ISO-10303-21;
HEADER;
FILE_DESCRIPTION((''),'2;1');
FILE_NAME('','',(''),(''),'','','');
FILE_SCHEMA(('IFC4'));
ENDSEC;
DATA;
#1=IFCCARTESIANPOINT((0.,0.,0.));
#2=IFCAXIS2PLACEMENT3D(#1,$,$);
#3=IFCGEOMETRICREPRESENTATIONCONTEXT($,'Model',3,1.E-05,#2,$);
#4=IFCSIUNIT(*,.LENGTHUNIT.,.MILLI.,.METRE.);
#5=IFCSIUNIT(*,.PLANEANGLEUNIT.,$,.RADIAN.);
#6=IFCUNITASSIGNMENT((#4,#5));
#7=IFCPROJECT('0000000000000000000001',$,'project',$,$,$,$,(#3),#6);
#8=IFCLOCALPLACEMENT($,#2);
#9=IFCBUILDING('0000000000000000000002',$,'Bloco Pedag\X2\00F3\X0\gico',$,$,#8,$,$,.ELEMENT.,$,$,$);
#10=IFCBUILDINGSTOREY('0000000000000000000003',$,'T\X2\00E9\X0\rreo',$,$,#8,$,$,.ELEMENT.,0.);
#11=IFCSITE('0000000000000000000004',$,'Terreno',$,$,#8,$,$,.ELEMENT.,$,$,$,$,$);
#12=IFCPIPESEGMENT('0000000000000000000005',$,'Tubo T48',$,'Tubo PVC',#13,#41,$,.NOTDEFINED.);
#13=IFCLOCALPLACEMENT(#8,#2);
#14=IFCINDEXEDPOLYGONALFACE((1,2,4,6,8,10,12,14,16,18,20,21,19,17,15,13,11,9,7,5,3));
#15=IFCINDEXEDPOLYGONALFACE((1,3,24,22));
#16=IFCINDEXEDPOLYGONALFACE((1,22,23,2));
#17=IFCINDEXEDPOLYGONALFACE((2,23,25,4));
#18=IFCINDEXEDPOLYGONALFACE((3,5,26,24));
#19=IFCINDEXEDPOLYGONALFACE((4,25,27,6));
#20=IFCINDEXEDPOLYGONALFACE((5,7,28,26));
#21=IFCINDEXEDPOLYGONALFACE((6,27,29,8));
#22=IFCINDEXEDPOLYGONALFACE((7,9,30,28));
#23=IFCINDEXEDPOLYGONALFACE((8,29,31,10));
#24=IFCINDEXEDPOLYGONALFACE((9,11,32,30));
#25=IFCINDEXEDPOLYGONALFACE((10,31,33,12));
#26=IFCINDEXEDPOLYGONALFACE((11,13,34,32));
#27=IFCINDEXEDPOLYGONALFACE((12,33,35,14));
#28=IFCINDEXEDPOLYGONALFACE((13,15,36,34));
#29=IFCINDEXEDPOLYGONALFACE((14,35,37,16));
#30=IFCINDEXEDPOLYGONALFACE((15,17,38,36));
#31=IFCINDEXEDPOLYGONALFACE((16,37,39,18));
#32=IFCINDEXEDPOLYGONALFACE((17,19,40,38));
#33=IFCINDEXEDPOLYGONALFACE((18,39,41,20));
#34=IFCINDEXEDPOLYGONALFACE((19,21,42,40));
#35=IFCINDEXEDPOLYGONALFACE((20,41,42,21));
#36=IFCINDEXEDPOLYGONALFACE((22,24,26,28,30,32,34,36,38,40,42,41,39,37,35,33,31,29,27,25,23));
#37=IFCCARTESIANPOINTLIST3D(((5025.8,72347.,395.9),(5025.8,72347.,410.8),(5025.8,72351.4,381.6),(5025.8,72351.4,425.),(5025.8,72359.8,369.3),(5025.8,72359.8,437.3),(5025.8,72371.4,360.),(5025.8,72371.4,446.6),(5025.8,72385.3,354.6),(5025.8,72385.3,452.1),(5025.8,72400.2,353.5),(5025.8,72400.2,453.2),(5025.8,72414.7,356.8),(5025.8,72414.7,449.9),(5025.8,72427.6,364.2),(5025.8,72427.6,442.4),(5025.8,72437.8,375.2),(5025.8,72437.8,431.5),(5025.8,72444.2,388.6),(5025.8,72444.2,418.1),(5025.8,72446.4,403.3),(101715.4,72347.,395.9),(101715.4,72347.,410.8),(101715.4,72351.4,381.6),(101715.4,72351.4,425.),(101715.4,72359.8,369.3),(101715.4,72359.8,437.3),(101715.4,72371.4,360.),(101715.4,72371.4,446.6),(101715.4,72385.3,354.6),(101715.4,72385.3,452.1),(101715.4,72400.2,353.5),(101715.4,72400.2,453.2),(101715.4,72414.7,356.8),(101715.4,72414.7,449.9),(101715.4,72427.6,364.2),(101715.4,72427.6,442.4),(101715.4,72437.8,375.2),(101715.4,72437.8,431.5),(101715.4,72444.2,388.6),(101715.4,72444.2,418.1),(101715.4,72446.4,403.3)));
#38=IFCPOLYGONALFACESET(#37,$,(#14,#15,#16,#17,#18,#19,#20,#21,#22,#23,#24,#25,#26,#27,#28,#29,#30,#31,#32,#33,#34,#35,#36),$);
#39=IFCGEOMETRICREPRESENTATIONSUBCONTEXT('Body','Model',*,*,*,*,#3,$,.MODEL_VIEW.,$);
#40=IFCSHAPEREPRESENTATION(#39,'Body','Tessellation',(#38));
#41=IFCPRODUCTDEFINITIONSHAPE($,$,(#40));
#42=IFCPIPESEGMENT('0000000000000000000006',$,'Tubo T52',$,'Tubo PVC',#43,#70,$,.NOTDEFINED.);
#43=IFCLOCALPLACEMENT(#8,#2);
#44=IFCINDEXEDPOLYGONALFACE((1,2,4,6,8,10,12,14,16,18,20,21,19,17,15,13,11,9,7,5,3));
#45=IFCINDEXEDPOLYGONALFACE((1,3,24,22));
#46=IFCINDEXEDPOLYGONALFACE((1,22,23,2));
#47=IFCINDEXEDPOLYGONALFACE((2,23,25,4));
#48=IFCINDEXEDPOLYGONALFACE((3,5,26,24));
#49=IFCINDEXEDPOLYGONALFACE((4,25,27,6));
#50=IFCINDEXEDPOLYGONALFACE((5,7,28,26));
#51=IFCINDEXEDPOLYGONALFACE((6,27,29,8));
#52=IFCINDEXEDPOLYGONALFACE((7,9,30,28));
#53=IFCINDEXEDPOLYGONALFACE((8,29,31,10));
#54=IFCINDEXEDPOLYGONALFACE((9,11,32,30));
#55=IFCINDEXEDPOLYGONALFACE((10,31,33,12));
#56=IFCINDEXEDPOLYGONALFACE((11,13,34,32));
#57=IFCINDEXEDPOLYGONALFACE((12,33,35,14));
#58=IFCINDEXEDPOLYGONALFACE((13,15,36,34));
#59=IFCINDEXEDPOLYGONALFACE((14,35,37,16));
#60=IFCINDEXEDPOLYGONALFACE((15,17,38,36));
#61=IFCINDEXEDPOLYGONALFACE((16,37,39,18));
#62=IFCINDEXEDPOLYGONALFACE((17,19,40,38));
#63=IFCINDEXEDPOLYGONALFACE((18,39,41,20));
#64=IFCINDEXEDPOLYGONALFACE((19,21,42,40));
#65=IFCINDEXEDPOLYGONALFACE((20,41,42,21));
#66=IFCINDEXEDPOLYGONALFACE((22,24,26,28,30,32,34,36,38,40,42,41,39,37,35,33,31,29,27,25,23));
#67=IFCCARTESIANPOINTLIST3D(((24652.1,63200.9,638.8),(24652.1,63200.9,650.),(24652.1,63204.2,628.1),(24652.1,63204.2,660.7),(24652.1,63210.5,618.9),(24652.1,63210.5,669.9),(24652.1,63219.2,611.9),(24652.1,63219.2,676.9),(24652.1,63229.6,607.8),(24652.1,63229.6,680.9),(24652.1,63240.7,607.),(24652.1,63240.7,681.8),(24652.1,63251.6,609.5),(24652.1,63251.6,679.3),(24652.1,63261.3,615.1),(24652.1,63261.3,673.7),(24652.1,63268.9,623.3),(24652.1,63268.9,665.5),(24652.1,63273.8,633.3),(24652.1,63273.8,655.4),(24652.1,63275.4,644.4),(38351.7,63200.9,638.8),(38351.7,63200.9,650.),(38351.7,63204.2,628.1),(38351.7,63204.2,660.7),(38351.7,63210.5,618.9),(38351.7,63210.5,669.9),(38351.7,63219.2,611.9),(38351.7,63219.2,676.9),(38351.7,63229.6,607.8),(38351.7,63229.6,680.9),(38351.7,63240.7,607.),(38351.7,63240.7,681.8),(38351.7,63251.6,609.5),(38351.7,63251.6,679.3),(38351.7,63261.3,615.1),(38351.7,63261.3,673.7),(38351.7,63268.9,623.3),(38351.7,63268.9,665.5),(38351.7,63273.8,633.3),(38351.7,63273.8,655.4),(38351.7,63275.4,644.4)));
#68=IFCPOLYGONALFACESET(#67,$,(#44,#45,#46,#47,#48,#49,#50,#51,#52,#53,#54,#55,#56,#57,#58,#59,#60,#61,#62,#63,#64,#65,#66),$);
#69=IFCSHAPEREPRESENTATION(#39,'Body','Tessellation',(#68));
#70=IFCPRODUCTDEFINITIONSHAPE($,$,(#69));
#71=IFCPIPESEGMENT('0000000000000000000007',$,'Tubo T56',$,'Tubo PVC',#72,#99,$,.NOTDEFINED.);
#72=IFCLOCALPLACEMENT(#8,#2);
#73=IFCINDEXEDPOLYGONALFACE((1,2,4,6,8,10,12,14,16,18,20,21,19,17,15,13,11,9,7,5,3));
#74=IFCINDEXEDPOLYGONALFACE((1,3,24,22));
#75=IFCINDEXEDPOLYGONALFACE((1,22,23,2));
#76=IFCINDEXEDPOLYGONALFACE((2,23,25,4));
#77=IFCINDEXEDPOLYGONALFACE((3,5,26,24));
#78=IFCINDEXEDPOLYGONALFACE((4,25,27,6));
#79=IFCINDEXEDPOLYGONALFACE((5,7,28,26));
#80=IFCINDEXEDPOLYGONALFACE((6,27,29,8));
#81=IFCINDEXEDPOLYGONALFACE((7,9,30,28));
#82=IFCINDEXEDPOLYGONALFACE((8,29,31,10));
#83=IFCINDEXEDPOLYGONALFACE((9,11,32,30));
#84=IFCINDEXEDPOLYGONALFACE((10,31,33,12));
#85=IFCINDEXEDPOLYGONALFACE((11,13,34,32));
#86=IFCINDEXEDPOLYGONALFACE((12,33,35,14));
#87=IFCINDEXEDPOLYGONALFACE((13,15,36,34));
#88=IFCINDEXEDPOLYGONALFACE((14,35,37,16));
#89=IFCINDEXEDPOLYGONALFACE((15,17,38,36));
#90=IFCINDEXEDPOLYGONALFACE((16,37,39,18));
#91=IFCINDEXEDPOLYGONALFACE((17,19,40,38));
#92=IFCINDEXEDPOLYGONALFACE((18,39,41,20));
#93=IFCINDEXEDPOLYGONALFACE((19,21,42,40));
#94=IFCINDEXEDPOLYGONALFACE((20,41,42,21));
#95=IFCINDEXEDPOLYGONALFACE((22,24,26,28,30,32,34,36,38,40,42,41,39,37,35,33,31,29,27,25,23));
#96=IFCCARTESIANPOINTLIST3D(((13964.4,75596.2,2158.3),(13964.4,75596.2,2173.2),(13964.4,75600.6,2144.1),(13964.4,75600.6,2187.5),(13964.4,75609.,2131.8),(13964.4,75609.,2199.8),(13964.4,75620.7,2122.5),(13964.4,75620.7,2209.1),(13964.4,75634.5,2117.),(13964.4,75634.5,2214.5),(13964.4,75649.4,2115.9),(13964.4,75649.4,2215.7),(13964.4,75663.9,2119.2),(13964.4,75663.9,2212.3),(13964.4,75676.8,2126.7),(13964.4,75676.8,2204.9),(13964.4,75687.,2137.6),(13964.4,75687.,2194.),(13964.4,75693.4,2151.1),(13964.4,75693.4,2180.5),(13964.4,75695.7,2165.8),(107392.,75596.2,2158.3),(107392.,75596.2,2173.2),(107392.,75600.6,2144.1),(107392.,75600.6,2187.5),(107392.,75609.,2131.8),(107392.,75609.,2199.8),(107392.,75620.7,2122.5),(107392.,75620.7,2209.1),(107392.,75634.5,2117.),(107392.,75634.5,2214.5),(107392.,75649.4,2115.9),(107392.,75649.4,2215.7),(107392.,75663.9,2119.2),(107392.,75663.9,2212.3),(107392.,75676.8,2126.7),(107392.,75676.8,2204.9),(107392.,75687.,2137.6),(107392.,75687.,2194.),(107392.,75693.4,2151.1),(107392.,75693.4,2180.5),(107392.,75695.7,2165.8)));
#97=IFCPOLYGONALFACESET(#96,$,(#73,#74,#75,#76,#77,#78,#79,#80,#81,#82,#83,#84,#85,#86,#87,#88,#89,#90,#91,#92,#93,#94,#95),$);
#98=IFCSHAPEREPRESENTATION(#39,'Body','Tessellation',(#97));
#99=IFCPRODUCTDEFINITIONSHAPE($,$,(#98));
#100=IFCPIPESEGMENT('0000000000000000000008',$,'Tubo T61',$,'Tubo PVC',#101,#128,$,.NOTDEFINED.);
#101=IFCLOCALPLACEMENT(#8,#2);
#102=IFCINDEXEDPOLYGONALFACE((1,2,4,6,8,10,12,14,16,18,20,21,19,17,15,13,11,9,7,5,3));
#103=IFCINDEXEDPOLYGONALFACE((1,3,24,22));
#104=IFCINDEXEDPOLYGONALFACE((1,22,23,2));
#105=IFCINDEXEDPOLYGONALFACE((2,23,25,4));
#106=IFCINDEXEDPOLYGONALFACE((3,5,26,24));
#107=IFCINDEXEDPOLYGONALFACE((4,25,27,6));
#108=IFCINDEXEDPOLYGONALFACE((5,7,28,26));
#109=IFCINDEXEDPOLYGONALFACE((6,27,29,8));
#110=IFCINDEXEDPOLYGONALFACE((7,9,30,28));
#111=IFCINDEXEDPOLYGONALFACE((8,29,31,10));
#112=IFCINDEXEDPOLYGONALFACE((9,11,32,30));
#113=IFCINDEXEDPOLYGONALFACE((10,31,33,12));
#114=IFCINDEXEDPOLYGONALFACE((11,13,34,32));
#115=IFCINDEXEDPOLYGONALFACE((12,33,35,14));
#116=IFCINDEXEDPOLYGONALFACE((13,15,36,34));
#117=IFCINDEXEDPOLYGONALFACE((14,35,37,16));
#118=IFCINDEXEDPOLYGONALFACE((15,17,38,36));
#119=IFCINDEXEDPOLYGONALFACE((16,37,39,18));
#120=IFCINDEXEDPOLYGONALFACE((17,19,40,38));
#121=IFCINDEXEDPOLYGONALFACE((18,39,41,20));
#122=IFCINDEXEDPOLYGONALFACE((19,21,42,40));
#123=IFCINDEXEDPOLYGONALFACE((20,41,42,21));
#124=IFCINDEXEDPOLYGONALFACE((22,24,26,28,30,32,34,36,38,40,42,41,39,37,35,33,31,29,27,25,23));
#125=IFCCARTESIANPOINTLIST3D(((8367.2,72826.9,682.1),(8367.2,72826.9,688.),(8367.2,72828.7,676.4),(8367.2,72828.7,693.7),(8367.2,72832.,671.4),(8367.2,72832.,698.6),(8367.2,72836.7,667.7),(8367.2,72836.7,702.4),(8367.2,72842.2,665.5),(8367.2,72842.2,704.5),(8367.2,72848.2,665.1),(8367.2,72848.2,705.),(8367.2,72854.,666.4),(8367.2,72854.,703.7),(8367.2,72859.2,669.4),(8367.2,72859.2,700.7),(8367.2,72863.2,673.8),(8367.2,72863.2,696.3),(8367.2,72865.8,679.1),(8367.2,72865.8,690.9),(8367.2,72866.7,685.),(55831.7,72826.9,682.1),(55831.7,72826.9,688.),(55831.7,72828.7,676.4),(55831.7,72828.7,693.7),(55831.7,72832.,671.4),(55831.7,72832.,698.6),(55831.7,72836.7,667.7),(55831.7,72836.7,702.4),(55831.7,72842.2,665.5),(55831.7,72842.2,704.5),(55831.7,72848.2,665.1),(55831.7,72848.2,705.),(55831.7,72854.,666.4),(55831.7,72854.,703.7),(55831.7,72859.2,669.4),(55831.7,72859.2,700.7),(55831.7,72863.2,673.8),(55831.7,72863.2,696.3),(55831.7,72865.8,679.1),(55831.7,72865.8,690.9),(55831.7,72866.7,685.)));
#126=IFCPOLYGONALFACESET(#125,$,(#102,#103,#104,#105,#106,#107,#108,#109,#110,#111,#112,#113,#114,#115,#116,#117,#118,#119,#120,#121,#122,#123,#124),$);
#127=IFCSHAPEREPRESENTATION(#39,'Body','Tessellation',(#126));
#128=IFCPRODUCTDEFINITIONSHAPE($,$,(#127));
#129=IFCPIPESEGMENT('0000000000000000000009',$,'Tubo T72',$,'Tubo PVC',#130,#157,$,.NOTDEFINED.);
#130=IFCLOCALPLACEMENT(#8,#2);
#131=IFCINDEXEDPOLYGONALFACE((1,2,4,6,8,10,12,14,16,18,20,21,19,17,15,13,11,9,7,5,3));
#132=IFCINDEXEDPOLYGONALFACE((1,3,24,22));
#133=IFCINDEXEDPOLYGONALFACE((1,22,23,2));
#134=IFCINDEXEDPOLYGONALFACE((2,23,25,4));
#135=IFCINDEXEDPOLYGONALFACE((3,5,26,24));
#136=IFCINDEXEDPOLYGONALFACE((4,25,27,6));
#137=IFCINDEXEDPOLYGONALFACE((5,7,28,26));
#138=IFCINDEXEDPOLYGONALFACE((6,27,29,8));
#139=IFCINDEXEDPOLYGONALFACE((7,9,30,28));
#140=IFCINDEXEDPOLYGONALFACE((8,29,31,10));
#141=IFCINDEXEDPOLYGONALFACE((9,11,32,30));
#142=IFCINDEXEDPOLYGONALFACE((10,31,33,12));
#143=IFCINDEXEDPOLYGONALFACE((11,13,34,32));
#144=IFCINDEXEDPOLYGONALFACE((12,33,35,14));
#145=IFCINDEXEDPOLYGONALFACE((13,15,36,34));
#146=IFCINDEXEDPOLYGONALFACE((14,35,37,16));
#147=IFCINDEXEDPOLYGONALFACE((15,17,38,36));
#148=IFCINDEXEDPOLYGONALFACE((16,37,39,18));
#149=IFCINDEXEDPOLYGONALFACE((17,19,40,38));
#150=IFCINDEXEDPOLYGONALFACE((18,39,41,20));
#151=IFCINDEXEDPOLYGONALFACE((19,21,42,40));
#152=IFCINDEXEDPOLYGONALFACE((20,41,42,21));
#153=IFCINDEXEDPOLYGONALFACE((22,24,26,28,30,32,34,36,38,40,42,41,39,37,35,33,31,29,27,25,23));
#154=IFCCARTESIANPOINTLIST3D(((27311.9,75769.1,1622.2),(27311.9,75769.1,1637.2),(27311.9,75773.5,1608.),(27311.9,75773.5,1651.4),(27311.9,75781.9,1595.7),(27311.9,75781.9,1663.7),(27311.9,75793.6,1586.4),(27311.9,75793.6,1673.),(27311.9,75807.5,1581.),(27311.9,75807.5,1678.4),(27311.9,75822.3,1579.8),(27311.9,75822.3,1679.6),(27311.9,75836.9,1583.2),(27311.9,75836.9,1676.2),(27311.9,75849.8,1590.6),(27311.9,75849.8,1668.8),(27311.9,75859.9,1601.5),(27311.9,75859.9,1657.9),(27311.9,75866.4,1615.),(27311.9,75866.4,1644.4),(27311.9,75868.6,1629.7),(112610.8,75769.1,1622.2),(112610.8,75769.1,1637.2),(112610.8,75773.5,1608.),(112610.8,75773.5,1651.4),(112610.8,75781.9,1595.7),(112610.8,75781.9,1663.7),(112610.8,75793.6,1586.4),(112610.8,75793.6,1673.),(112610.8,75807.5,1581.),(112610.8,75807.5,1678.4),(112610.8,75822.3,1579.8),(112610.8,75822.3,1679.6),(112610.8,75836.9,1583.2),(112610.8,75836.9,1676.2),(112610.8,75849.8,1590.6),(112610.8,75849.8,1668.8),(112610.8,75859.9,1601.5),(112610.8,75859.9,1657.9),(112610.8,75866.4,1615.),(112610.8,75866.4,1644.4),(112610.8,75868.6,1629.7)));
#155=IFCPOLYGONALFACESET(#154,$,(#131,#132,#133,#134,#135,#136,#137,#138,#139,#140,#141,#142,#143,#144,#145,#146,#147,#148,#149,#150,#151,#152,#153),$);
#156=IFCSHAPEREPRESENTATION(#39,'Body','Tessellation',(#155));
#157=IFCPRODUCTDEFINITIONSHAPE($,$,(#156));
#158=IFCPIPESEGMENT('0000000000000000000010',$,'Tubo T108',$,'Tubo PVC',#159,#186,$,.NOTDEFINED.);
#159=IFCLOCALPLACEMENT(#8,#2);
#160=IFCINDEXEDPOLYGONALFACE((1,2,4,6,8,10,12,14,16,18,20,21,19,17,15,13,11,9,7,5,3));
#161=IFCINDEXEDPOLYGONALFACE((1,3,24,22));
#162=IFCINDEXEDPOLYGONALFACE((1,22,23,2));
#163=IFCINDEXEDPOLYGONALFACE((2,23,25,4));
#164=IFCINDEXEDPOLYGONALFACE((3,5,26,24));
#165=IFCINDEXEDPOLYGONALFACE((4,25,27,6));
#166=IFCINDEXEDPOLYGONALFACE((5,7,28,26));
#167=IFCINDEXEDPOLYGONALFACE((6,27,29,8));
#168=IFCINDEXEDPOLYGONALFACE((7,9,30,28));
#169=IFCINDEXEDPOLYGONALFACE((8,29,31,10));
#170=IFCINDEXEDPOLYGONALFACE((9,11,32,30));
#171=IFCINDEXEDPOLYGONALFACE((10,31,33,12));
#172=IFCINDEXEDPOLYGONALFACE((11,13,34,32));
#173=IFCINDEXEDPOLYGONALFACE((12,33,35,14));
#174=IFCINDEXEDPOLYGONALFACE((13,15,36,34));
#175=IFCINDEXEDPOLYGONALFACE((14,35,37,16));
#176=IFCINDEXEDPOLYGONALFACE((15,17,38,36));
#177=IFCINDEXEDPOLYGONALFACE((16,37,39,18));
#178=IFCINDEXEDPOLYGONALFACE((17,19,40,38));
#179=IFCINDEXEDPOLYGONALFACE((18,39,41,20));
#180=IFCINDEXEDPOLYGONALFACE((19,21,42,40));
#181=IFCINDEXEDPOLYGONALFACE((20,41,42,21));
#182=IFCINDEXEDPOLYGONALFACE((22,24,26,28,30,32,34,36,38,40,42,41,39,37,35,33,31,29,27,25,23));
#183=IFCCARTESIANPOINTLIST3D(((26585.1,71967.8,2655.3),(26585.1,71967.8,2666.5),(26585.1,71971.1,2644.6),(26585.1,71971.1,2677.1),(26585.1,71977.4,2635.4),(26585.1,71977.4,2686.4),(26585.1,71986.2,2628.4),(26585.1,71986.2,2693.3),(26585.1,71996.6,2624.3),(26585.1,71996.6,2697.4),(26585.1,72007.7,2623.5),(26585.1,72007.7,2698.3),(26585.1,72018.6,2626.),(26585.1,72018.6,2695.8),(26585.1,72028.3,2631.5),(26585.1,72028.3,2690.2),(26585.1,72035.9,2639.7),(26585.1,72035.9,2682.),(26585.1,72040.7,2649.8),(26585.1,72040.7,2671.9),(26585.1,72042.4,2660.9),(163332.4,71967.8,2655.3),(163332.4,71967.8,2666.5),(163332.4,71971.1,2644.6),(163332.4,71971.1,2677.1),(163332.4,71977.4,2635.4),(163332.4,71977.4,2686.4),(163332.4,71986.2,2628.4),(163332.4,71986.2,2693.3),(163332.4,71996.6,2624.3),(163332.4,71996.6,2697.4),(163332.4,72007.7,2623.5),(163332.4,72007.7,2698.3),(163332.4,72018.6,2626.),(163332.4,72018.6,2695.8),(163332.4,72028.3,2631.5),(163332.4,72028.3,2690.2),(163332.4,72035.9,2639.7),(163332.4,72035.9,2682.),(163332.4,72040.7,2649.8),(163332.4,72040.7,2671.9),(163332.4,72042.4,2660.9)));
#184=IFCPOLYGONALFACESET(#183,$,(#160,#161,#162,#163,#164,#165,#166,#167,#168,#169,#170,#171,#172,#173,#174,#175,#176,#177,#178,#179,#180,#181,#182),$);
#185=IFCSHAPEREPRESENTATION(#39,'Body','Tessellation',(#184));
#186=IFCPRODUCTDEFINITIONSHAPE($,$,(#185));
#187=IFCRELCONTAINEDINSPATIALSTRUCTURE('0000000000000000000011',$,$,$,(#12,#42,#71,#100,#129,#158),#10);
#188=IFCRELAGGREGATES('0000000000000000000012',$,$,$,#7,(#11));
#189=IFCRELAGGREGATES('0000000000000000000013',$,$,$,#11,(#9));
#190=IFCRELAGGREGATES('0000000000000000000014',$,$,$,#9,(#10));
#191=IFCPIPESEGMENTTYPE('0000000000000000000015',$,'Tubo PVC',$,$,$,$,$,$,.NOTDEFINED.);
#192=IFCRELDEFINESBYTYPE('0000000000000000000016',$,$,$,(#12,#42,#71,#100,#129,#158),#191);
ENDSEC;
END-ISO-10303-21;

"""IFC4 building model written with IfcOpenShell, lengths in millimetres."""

from ifc_helpers import new_model, si_unit, frame, origin, origin_2d, place, context, subcontext, project, spatial, circle, extrude, type_object, element, save


model = new_model("IFC4")

# Units and contexts
model_context = context("Model", 3, precision=1e-05, world=origin())
body_context = subcontext(model_context, "Body", "Model", "MODEL_VIEW")
ifc_project = project(units=[si_unit("LENGTHUNIT", "METRE", prefix="MILLI"), si_unit("PLANEANGLEUNIT", "RADIAN")], contexts=[model_context])

# Site, building, storey
placement = place(None, origin())
site = spatial("IfcSite", under=ifc_project, at=placement, Name="Terreno", CompositionType="ELEMENT")
building = spatial("IfcBuilding", under=site, at=placement, Name="Bloco Pedagógico", CompositionType="ELEMENT")
storey = spatial("IfcBuildingStorey", under=building, at=placement, Name="Térreo", CompositionType="ELEMENT", Elevation=0.0)

# Pipe segments
pipe_segment_type = type_object("IfcPipeSegmentType", Name="Tubo PVC", PredefinedType="NOTDEFINED")
pipe_segment_1_placement = place(None, frame((5025.8, 72396.4, 403.3), z_axis=(1.0, 0.0, 0.0), x_axis=(0.0, 1.0, 0.0)))
element("IfcPipeSegment", 1, at=pipe_segment_1_placement, inside=storey, type_object=pipe_segment_type, Name="Tubo T48", ObjectType="Tubo PVC", PredefinedType="NOTDEFINED", context=body_context, shape_type="SweptSolid", body=[
    extrude(circle(Radius=50.0, at=origin_2d()), None, (0.0, 0.0, 1.0), 96689.6),
])
pipe_segment_2_placement = place(None, frame((24652.1, 63237.9, 644.4), z_axis=(1.0, 0.0, 0.0), x_axis=(0.0, 1.0, 0.0)))
element("IfcPipeSegment", 2, at=pipe_segment_2_placement, inside=storey, type_object=pipe_segment_type, Name="Tubo T52", ObjectType="Tubo PVC", PredefinedType="NOTDEFINED", context=body_context, shape_type="SweptSolid", body=[
    extrude(circle(Radius=37.5, at=origin_2d()), None, (0.0, 0.0, 1.0), 13699.6),
])
pipe_segment_3_placement = place(None, frame((13964.4, 75645.7, 2165.8), z_axis=(1.0, 0.0, 0.0), x_axis=(0.0, 1.0, 0.0)))
element("IfcPipeSegment", 3, at=pipe_segment_3_placement, inside=storey, type_object=pipe_segment_type, Name="Tubo T56", ObjectType="Tubo PVC", PredefinedType="NOTDEFINED", context=body_context, shape_type="SweptSolid", body=[
    extrude(circle(Radius=50.0, at=origin_2d()), None, (0.0, 0.0, 1.0), 93427.6),
])
pipe_segment_4_placement = place(None, frame((8367.2, 72846.7, 685.0), z_axis=(1.0, 0.0, 0.0), x_axis=(0.0, 1.0, 0.0)))
element("IfcPipeSegment", 4, at=pipe_segment_4_placement, inside=storey, type_object=pipe_segment_type, Name="Tubo T61", ObjectType="Tubo PVC", PredefinedType="NOTDEFINED", context=body_context, shape_type="SweptSolid", body=[
    extrude(circle(Radius=20.0, at=origin_2d()), None, (0.0, 0.0, 1.0), 47464.4),
])
pipe_segment_5_placement = place(None, frame((27311.9, 75818.6, 1629.7), z_axis=(1.0, 0.0, 0.0), x_axis=(0.0, 1.0, 0.0)))
element("IfcPipeSegment", 5, at=pipe_segment_5_placement, inside=storey, type_object=pipe_segment_type, Name="Tubo T72", ObjectType="Tubo PVC", PredefinedType="NOTDEFINED", context=body_context, shape_type="SweptSolid", body=[
    extrude(circle(Radius=50.0, at=origin_2d()), None, (0.0, 0.0, 1.0), 85298.9),
])
pipe_segment_6_placement = place(None, frame((26585.1, 72004.9, 2660.9), z_axis=(1.0, 0.0, 0.0), x_axis=(0.0, 1.0, 0.0)))
element("IfcPipeSegment", 6, at=pipe_segment_6_placement, inside=storey, type_object=pipe_segment_type, Name="Tubo T108", ObjectType="Tubo PVC", PredefinedType="NOTDEFINED", context=body_context, shape_type="SweptSolid", body=[
    extrude(circle(Radius=37.5, at=origin_2d()), None, (0.0, 0.0, 1.0), 136747.4),
])

save(model, "model.ifc")
